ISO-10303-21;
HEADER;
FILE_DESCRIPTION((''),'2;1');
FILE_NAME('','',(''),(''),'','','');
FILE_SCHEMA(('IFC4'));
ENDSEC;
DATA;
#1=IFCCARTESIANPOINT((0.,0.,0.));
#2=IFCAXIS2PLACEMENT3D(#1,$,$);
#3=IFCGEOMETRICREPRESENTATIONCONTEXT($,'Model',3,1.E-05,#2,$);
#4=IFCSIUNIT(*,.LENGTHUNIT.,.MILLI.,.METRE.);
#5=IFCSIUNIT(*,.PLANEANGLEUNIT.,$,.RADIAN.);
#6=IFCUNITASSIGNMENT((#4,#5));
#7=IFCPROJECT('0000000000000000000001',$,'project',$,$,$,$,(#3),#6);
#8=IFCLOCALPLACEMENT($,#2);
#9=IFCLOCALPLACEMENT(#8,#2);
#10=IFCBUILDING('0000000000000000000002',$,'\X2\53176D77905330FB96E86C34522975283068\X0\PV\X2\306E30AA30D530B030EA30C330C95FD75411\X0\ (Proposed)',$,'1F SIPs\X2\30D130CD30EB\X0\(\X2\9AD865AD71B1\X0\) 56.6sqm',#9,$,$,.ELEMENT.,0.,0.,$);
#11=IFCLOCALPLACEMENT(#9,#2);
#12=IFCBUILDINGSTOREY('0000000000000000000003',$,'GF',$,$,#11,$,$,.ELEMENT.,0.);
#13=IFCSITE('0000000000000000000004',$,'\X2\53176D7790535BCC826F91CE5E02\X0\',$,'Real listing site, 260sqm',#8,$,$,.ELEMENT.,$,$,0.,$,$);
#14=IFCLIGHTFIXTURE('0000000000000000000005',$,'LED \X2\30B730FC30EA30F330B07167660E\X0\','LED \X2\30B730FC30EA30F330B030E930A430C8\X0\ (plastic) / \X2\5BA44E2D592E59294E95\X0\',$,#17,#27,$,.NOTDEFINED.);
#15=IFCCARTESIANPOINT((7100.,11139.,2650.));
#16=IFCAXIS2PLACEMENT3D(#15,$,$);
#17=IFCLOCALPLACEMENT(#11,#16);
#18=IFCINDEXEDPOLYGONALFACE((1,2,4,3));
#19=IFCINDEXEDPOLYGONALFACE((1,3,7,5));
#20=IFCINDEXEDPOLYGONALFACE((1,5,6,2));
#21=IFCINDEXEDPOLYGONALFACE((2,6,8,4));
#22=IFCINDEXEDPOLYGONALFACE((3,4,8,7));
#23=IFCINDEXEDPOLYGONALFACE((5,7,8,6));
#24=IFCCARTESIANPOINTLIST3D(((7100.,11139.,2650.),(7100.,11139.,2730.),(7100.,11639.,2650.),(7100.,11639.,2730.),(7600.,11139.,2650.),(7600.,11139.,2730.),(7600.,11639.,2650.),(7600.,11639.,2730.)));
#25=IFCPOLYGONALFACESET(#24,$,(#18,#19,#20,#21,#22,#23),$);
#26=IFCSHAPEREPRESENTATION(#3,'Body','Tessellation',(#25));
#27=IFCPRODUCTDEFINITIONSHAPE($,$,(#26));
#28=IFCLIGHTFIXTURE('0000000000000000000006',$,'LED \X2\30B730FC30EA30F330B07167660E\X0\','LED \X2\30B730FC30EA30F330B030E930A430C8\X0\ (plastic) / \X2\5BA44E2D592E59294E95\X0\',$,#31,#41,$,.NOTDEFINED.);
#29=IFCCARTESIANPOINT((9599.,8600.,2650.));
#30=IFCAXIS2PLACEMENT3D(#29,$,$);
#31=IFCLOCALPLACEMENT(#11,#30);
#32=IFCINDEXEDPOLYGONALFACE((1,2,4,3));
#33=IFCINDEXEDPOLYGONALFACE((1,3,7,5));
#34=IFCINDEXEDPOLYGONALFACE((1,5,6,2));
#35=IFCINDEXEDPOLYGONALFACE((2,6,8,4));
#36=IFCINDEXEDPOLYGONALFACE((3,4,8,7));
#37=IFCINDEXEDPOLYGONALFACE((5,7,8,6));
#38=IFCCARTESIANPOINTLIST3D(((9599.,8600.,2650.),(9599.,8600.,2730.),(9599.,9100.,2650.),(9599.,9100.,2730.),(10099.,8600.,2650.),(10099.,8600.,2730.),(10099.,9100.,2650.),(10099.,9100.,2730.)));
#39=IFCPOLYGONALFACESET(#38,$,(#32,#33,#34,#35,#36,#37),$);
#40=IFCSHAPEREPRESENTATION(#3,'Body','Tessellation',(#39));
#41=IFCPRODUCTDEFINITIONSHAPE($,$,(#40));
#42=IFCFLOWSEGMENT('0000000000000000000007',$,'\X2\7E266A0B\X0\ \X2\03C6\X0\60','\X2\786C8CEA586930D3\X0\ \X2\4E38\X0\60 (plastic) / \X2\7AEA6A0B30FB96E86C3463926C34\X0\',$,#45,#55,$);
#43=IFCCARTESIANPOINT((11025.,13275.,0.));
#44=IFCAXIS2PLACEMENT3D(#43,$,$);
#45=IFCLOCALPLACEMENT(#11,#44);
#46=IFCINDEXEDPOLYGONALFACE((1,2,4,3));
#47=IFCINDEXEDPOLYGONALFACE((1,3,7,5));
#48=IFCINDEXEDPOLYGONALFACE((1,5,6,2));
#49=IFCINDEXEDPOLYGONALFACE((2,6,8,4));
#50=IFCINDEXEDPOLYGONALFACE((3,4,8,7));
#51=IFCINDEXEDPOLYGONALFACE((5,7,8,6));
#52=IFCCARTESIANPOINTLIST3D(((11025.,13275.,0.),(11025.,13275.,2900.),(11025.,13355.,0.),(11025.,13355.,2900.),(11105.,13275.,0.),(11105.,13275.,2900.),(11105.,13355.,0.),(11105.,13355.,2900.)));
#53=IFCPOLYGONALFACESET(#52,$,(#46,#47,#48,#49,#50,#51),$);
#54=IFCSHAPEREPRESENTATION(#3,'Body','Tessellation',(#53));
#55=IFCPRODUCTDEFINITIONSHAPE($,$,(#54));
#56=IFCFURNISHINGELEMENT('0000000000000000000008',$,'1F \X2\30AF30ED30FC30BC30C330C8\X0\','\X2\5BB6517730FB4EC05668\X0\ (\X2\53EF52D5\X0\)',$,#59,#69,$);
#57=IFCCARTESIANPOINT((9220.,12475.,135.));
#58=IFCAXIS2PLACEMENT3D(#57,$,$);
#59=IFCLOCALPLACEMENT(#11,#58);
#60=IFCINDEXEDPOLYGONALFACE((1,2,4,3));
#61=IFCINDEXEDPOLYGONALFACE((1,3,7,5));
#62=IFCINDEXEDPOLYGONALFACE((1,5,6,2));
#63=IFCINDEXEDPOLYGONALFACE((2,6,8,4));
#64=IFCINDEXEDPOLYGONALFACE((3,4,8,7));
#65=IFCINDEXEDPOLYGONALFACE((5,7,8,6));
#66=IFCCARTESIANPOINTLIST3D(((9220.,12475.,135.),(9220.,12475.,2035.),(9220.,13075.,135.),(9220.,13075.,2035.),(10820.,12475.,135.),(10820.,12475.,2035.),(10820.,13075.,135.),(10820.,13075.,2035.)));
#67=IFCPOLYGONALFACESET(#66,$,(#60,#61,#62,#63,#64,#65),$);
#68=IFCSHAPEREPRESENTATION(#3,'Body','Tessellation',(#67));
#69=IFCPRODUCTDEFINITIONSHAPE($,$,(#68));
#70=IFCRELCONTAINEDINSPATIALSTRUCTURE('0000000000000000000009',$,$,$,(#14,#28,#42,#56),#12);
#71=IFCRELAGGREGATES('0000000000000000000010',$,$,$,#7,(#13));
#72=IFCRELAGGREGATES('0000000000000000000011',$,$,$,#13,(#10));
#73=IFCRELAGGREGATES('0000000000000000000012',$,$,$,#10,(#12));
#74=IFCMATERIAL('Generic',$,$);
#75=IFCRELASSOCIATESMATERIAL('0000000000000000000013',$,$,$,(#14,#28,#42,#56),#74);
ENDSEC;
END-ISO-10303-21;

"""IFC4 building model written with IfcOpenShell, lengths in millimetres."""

from ifc_helpers import new_model, si_unit, frame, frame_2d, origin, place, context, project, spatial, rectangle, extrude, material, element, save


model = new_model("IFC4")

# Units and contexts
model_context = context("Model", 3, precision=1e-05, world=origin())
ifc_project = project(units=[si_unit("LENGTHUNIT", "METRE", prefix="MILLI"), si_unit("PLANEANGLEUNIT", "RADIAN")], contexts=[model_context])

# Site, building, storey
site_placement = place(None, origin())
site = spatial("IfcSite", under=ifc_project, at=site_placement, Name="北海道富良野市", ObjectType="Real listing site, 260sqm", CompositionType="ELEMENT", RefElevation=0.0)
building_placement = place(site_placement, origin())
building = spatial("IfcBuilding", under=site, at=building_placement, Name="北海道・雨水利用とPVのオフグリッド志向 (Proposed)", ObjectType="1F SIPsパネル(高断熱) 56.6sqm", CompositionType="ELEMENT", ElevationOfRefHeight=0.0, ElevationOfTerrain=0.0)
storey_placement = place(building_placement, origin())
storey = spatial("IfcBuildingStorey", under=building, at=storey_placement, Name="GF", CompositionType="ELEMENT", Elevation=0.0)

# Shared definitions
ifc_material_1 = material(Name="Generic")

# Light fixtures
light_fixture_1_placement = place(storey_placement, frame((7100.0, 11139.0, 2650.0)))
element("IfcLightFixture", 1, at=light_fixture_1_placement, inside=storey, material=ifc_material_1, Name="LED シーリング照明", Description="LED シーリングライト (plastic) / 室中央天井", PredefinedType="NOTDEFINED", context=model_context, shape_type="SweptSolid", body=[
    extrude(rectangle(XDim=500.0, YDim=500.0, at=frame_2d((250.0, 250.0))), frame((7100.0, 11139.0, 2650.0)), (0.0, 0.0, 1.0), 80.0),
])
light_fixture_2_placement = place(storey_placement, frame((9599.0, 8600.0, 2650.0)))
element("IfcLightFixture", 2, at=light_fixture_2_placement, inside=storey, material=ifc_material_1, Name="LED シーリング照明", Description="LED シーリングライト (plastic) / 室中央天井", PredefinedType="NOTDEFINED", context=model_context, shape_type="SweptSolid", body=[
    extrude(rectangle(XDim=500.0, YDim=500.0, at=frame_2d((250.0, 250.0))), frame((9599.0, 8600.0, 2650.0)), (0.0, 0.0, 1.0), 80.0),
])

# Flow segment
flow_segment_placement = place(storey_placement, frame((11025.0, 13275.0, 0.0)))
element("IfcFlowSegment", 3, at=flow_segment_placement, inside=storey, material=ifc_material_1, Name="縦樋 φ60", Description="硬質塩ビ 丸60 (plastic) / 竪樋・雨水排水", context=model_context, shape_type="SweptSolid", body=[
    extrude(rectangle(XDim=80.0, YDim=80.0, at=frame_2d((40.0, 40.0))), frame((11025.0, 13275.0, 0.0)), (0.0, 0.0, 1.0), 2900.0),
])

# Furnishing element
furnishing_placement = place(storey_placement, frame((9220.0, 12475.0, 135.0)))
element("IfcFurnishingElement", 4, at=furnishing_placement, inside=storey, material=ifc_material_1, Name="1F クローゼット", Description="家具・什器 (可動)", context=model_context, shape_type="SweptSolid", body=[
    extrude(rectangle(XDim=1600.0, YDim=600.0, at=frame_2d((800.0, 300.0))), frame((9220.0, 12475.0, 135.0)), (0.0, 0.0, 1.0), 1900.0),
])

save(model, "model.ifc")
